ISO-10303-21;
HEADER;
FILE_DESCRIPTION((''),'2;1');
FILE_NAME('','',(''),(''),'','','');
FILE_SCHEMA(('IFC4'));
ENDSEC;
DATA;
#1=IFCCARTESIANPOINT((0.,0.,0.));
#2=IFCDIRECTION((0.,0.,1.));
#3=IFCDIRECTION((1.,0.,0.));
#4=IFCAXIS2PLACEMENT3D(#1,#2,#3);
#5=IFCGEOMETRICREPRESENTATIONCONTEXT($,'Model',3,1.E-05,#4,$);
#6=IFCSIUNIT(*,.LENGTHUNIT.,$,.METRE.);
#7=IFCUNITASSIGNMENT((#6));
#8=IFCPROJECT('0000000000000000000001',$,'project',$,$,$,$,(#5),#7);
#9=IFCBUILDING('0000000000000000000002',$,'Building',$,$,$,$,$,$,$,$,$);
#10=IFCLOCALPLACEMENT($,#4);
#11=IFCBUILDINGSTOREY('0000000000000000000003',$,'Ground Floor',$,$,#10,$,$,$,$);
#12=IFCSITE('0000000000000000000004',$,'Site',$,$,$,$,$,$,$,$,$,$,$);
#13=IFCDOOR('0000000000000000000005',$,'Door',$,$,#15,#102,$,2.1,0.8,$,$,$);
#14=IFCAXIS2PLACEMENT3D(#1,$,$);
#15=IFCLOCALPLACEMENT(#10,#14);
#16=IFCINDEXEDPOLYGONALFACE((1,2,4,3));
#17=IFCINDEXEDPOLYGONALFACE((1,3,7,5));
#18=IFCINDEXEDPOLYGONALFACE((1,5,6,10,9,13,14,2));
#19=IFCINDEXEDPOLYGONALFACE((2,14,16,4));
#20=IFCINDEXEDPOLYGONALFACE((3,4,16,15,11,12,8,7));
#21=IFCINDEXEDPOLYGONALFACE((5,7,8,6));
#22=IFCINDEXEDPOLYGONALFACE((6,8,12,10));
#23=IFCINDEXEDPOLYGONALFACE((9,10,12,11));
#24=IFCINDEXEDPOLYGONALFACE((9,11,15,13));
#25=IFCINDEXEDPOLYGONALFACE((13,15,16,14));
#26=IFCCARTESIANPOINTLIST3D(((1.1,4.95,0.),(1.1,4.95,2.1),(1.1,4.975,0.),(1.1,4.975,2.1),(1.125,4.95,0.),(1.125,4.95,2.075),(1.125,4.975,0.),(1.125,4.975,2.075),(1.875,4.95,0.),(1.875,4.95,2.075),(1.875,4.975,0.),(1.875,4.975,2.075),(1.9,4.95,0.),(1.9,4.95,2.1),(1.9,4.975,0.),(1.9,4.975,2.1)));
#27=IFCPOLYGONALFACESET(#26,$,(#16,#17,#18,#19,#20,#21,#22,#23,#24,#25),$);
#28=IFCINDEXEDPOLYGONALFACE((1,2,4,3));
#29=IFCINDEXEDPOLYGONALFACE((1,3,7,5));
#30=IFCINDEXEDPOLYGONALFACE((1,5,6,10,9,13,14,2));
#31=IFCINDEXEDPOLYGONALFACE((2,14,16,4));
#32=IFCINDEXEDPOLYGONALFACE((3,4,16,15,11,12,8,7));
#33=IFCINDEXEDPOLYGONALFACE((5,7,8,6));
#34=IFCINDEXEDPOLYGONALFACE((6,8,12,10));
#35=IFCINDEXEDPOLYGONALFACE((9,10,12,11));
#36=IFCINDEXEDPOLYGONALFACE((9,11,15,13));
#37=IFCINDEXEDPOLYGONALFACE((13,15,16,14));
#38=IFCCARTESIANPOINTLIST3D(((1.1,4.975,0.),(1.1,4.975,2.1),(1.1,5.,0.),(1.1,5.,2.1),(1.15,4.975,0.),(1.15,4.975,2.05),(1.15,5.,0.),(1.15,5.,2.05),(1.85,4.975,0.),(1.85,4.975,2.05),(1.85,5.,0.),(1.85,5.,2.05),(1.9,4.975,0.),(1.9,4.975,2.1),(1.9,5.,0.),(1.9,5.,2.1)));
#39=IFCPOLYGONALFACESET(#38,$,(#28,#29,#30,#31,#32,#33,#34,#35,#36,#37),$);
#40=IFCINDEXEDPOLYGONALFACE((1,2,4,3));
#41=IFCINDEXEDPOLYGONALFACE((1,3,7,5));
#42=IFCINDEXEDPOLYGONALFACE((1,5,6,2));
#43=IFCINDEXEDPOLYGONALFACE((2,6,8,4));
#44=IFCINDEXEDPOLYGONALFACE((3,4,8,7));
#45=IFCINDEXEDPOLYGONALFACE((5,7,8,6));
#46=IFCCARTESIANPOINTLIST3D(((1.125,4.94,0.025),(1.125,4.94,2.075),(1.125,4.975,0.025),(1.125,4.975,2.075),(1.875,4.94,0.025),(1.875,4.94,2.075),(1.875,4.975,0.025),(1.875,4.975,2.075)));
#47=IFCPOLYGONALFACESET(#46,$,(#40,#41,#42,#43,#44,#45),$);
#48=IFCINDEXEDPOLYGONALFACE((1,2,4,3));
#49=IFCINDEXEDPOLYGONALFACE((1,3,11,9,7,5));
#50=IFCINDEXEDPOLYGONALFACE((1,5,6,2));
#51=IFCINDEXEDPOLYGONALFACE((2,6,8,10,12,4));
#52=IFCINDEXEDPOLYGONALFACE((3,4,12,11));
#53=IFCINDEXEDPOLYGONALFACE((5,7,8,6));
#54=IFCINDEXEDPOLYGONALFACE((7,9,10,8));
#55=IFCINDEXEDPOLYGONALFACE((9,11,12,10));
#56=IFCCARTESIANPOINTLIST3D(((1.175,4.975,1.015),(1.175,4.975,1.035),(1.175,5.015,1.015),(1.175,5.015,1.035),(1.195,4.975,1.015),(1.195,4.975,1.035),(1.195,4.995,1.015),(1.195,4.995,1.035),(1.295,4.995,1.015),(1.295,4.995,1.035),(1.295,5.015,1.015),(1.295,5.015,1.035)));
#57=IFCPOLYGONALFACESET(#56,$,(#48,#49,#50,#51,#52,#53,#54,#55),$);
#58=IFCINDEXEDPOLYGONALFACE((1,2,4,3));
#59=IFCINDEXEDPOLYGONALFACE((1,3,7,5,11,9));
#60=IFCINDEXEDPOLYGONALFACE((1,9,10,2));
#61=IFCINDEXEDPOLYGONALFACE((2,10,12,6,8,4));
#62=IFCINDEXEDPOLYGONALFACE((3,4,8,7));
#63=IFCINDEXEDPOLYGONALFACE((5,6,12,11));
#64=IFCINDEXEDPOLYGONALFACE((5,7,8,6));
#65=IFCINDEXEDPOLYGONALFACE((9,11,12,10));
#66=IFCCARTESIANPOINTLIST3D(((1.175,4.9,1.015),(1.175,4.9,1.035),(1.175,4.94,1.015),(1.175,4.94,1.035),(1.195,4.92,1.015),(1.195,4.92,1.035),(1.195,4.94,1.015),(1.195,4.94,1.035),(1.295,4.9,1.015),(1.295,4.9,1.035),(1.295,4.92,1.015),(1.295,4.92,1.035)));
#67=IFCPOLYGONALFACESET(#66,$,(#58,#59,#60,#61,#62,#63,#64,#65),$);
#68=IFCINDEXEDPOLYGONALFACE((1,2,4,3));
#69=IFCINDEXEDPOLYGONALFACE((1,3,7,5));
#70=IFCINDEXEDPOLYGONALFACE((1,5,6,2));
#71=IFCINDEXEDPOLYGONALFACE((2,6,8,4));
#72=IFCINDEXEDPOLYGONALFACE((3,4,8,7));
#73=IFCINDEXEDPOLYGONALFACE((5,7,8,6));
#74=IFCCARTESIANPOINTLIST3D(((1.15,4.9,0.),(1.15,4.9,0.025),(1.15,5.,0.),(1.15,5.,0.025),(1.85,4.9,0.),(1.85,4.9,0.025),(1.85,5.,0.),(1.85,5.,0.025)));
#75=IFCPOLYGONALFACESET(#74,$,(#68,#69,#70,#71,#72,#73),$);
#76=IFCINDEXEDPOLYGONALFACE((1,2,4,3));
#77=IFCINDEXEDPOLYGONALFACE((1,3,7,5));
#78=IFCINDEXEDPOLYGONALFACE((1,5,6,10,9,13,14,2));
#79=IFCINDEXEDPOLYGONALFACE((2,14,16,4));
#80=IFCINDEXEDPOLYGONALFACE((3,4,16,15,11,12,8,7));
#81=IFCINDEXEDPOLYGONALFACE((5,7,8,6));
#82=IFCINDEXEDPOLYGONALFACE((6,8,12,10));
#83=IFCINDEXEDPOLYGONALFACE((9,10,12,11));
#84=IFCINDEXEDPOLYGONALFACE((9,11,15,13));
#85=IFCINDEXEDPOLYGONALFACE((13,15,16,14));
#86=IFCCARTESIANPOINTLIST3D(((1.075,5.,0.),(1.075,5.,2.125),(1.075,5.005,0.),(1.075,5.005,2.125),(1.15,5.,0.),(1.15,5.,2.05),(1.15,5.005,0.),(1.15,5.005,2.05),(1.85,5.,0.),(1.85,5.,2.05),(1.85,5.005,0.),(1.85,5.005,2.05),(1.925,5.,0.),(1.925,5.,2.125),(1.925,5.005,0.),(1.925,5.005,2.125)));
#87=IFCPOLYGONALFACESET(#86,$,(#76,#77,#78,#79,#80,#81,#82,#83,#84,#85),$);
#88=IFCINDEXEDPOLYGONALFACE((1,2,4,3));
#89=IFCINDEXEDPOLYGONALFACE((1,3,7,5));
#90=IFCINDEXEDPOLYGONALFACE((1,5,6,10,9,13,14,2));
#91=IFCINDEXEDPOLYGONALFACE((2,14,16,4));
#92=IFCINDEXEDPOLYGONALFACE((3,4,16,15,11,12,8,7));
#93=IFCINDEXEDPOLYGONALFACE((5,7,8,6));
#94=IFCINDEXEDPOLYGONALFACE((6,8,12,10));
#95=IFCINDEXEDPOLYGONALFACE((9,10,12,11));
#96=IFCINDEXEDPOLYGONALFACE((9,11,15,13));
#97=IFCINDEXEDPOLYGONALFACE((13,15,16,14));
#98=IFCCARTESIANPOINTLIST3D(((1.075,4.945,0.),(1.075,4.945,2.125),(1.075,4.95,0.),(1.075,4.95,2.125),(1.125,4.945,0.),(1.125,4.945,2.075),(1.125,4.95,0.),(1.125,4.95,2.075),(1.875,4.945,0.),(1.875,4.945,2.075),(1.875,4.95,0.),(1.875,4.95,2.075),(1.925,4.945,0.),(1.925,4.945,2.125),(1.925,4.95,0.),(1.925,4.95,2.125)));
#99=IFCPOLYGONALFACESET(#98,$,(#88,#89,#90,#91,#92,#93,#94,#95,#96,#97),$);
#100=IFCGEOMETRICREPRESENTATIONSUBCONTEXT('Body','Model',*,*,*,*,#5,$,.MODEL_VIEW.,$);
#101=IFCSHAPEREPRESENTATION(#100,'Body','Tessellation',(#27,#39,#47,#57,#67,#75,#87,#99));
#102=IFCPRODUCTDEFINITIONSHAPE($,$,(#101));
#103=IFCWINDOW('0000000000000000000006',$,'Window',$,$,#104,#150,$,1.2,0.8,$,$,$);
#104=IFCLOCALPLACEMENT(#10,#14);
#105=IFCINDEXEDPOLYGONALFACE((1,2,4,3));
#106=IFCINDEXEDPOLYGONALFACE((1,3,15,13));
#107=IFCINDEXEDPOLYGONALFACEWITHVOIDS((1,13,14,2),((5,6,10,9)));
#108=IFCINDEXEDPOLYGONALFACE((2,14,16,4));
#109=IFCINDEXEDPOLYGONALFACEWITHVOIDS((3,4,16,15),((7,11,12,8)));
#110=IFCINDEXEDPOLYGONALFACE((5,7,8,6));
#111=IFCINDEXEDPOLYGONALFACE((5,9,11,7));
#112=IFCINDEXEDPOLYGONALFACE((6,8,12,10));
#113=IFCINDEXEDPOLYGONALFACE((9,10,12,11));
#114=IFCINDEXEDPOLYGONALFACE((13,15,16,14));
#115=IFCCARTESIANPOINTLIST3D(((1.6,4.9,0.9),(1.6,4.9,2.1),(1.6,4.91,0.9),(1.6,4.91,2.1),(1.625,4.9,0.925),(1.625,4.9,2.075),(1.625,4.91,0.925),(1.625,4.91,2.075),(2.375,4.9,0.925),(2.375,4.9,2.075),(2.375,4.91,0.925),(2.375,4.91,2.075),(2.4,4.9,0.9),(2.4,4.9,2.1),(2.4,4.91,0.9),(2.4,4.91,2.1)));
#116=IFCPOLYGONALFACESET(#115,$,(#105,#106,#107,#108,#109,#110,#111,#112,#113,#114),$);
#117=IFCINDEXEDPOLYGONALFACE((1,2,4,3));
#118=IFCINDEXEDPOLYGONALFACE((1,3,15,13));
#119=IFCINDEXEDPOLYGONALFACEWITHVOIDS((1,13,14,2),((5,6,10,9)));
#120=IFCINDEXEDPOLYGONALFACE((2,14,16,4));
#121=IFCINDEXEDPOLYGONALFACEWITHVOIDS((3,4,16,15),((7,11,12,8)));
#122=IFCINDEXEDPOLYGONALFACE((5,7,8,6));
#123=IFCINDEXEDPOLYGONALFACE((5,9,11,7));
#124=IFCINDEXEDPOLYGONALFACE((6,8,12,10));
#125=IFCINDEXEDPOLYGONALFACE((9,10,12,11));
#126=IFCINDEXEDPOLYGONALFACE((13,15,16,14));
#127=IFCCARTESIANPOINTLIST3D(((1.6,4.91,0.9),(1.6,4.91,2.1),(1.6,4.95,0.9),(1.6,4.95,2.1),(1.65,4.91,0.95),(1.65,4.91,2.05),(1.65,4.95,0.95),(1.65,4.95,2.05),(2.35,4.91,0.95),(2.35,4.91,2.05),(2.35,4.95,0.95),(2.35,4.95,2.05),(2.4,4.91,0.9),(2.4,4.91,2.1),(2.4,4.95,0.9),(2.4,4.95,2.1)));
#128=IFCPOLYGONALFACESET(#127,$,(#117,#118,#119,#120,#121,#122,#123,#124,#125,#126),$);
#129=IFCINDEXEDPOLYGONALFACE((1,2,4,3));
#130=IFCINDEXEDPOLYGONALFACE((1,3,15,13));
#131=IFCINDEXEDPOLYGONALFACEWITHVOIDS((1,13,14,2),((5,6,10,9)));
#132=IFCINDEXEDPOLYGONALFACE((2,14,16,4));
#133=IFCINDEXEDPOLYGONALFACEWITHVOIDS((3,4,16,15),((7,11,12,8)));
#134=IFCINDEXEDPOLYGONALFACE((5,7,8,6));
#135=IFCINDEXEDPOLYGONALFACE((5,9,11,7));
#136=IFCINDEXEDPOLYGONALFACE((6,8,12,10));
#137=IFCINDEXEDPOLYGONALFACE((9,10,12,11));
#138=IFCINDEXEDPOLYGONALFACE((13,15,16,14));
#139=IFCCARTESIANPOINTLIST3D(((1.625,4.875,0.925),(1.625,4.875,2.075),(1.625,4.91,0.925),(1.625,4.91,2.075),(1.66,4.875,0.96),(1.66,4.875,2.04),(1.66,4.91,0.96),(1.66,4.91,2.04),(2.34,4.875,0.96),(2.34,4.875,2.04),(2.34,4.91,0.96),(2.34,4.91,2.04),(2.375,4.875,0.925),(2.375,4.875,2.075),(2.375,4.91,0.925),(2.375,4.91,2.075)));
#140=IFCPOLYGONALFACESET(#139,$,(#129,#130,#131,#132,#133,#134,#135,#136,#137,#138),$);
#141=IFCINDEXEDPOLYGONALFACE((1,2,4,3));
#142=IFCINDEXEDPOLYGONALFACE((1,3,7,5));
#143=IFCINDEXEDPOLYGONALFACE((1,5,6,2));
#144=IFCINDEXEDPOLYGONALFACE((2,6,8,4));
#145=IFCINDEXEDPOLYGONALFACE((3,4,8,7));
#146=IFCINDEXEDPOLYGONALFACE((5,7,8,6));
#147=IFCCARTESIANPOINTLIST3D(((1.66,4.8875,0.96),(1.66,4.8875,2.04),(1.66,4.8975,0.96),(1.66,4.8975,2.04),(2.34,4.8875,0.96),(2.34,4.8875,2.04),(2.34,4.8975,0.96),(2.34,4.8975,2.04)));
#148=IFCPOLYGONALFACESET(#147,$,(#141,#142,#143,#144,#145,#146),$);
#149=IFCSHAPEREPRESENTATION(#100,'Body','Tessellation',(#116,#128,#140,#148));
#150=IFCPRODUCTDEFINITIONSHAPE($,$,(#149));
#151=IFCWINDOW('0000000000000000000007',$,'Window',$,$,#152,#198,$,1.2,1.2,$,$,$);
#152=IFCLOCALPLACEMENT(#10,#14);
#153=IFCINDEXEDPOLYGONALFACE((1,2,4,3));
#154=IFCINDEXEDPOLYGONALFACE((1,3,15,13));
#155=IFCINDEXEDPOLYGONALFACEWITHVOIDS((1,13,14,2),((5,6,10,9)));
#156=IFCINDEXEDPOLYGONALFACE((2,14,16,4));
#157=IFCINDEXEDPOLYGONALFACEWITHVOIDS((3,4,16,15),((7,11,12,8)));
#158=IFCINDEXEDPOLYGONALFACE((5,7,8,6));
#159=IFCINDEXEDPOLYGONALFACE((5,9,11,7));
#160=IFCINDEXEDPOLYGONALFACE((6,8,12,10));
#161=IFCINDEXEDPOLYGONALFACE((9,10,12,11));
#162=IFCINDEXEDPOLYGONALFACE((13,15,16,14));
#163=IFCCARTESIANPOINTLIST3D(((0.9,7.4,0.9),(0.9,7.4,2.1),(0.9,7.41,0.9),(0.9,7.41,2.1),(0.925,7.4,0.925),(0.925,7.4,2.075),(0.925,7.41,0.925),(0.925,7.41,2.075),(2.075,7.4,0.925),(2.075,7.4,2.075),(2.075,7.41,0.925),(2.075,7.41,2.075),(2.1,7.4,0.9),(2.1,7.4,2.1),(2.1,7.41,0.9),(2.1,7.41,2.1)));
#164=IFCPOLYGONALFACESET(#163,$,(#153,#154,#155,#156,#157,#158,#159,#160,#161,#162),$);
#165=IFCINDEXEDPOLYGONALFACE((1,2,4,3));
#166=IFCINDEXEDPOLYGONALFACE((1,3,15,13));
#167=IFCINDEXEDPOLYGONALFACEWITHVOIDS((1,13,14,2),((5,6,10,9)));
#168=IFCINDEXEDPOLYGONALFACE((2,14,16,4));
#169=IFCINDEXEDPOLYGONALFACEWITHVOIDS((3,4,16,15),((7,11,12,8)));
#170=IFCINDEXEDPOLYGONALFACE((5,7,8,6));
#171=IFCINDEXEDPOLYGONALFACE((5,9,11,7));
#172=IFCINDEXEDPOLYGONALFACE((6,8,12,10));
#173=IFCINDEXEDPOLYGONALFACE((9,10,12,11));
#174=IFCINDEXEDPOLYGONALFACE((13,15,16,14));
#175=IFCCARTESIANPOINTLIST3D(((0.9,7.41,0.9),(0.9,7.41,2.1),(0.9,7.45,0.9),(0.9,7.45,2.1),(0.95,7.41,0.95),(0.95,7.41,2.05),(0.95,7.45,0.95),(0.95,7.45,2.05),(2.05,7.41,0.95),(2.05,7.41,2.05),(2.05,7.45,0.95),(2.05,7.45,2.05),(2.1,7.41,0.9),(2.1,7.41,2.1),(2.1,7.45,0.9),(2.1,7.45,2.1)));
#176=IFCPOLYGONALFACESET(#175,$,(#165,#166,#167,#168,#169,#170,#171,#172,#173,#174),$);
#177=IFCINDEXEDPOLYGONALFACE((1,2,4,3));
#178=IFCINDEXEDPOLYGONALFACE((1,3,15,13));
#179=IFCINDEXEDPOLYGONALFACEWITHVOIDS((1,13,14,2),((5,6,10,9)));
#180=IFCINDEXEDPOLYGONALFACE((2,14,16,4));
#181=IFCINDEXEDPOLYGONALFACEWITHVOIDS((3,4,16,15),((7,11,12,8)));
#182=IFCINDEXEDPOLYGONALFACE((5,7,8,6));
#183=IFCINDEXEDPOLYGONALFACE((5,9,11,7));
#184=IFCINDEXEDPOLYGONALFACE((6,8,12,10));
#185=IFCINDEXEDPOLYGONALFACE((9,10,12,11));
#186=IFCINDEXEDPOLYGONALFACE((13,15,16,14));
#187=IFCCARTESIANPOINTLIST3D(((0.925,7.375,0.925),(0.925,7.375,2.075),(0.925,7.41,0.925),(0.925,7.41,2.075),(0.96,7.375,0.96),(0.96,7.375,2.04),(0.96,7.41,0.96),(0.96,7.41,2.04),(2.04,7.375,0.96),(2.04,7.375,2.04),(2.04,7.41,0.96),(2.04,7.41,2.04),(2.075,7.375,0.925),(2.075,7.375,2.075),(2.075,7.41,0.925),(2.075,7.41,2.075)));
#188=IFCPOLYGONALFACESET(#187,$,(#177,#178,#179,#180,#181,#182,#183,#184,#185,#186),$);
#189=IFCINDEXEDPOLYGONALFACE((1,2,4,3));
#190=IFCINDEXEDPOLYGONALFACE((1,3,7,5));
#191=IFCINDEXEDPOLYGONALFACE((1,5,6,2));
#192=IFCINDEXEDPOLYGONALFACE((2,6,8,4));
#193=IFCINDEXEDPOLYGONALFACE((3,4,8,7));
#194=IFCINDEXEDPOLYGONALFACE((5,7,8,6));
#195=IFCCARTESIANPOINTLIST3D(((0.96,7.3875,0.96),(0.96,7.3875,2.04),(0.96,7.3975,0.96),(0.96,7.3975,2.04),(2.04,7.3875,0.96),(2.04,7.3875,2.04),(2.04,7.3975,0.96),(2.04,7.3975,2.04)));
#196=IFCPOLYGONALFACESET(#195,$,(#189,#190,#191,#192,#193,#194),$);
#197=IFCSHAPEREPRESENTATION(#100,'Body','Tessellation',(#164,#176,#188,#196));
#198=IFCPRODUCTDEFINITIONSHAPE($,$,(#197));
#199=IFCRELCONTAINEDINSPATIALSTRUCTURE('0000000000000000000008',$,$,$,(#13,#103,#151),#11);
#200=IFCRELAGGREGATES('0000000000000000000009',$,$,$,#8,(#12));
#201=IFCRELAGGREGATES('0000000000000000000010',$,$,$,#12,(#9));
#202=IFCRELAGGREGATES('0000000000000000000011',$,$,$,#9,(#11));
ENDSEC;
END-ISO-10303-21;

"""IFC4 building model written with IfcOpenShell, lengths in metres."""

from ifc_helpers import new_model, si_unit, frame, origin_with_axes, place, context, subcontext, project, spatial, line, indexed_curve, outline, extrude, element, save


model = new_model("IFC4")

# Units and contexts
model_context = context("Model", 3, precision=1e-05, world=origin_with_axes())
body_context = subcontext(model_context, "Body", "Model", "MODEL_VIEW")
ifc_project = project(units=[si_unit("LENGTHUNIT", "METRE")], contexts=[model_context])

# Site, building, storey
site = spatial("IfcSite", under=ifc_project, Name="Site")
building = spatial("IfcBuilding", under=site, Name="Building")
storey_placement = place(None, origin_with_axes())
storey = spatial("IfcBuildingStorey", under=building, at=storey_placement, Name="Ground Floor")

# Door
door_1_placement = place(storey_placement, frame((1.9, 5.0, 0.0), z_axis=(0.0, 0.0, 1.0), x_axis=(-1.0, 0.0, 0.0)))
element("IfcDoor", 1, at=door_1_placement, inside=storey, Name="Door", OverallHeight=2.1, OverallWidth=0.8, context=body_context, shape_type="SweptSolid", body=[
    extrude(outline(indexed_curve([(0.0, 0.0), (0.0, 2.1), (0.8, 2.1), (0.8, 0.0), (0.775, 0.0), (0.775, 2.075), (0.025, 2.075), (0.025, 0.0)], segments=[line(1, 2, 3, 4, 5, 6, 7, 8, 1)])), frame((0.0, 0.025, 0.0), z_axis=(0.0, -1.0, 0.0), x_axis=(1.0, 0.0, 0.0)), (0.0, 0.0, -1.0), 0.025),
    extrude(outline(indexed_curve([(0.0, 0.0), (0.0, 2.1), (0.8, 2.1), (0.8, 0.0), (0.75, 0.0), (0.75, 2.05), (0.05, 2.05), (0.05, 0.0)], segments=[line(1, 2, 3, 4, 5, 6, 7, 8, 1)])), frame((0.0, 0.0, 0.0), z_axis=(0.0, -1.0, 0.0), x_axis=(1.0, 0.0, 0.0)), (0.0, 0.0, -1.0), 0.025),
    extrude(outline(indexed_curve([(0.0, 0.0), (0.75, 0.0), (0.75, 0.035), (0.0, 0.035)], segments=[line(1, 2, 3, 4, 1)])), frame((0.025, 0.025, 0.025), z_axis=(0.0, 0.0, 1.0), x_axis=(1.0, 0.0, 0.0)), (0.0, 0.0, 1.0), 2.05),
    extrude(outline(indexed_curve([(0.0, 0.0), (0.0, -0.04), (-0.12, -0.04), (-0.12, -0.02), (-0.02, -0.02), (-0.02, 0.0)], segments=[line(1, 2, 3, 4, 5, 6, 1)])), frame((0.725, 0.025, 1.015), z_axis=(0.0, 0.0, 1.0), x_axis=(1.0, 0.0, 0.0)), (0.0, 0.0, 1.0), 0.02),
    extrude(outline(indexed_curve([(0.0, 0.0), (0.0, 0.04), (-0.12, 0.04), (-0.12, 0.02), (-0.02, 0.02), (-0.02, 0.0)], segments=[line(1, 2, 3, 4, 5, 6, 1)])), frame((0.725, 0.06, 1.015), z_axis=(0.0, 0.0, 1.0), x_axis=(1.0, 0.0, 0.0)), (0.0, 0.0, 1.0), 0.02),
    extrude(outline(indexed_curve([(0.0, 0.0), (0.7, 0.0), (0.7, 0.1), (0.0, 0.1)], segments=[line(1, 2, 3, 4, 1)])), frame((0.05, 0.0, 0.0), z_axis=(0.0, 0.0, 1.0), x_axis=(1.0, 0.0, 0.0)), (0.0, 0.0, 1.0), 0.025),
    extrude(outline(indexed_curve([(0.0, 0.0), (0.0, 2.125), (0.85, 2.125), (0.85, 0.0), (0.775, 0.0), (0.775, 2.05), (0.075, 2.05), (0.075, 0.0)], segments=[line(1, 2, 3, 4, 5, 6, 7, 8, 1)])), frame((-0.025, -0.005, 0.0), z_axis=(0.0, -1.0, 0.0), x_axis=(1.0, 0.0, 0.0)), (0.0, 0.0, -1.0), 0.005),
    extrude(outline(indexed_curve([(0.0, 0.0), (0.0, 2.125), (0.85, 2.125), (0.85, 0.0), (0.8, 0.0), (0.8, 2.075), (0.05, 2.075), (0.05, 0.0)], segments=[line(1, 2, 3, 4, 5, 6, 7, 8, 1)])), frame((-0.025, 0.05, 0.0), z_axis=(0.0, -1.0, 0.0), x_axis=(1.0, 0.0, 0.0)), (0.0, 0.0, -1.0), 0.005),
])

# Windows
window_1_placement = place(storey_placement, frame((2.4, 5.0, 0.9), z_axis=(0.0, 0.0, 1.0), x_axis=(-1.0, 0.0, 0.0)))
element("IfcWindow", 2, at=window_1_placement, inside=storey, Name="Window", OverallHeight=1.2, OverallWidth=0.8, context=body_context, shape_type="SweptSolid", body=[
    extrude(outline(indexed_curve([(0.0, 0.0), (0.8, 0.0), (0.8, 1.2), (0.0, 1.2)], segments=[line(1, 2, 3, 4, 1)]), holes=[indexed_curve([(0.025, 0.025), (0.775, 0.025), (0.775, 1.175), (0.025, 1.175)], segments=[line(1, 2, 3, 4, 1)])]), frame((0.0, 0.09, 0.0), z_axis=(0.0, -1.0, 0.0), x_axis=(1.0, 0.0, 0.0)), (0.0, 0.0, -1.0), 0.01),
    extrude(outline(indexed_curve([(0.0, 0.0), (0.8, 0.0), (0.8, 1.2), (0.0, 1.2)], segments=[line(1, 2, 3, 4, 1)]), holes=[indexed_curve([(0.05, 0.05), (0.75, 0.05), (0.75, 1.15), (0.05, 1.15)], segments=[line(1, 2, 3, 4, 1)])]), frame((0.0, 0.05, 0.0), z_axis=(0.0, -1.0, 0.0), x_axis=(1.0, 0.0, 0.0)), (0.0, 0.0, -1.0), 0.04),
    extrude(outline(indexed_curve([(0.0, 0.0), (0.75, 0.0), (0.75, 1.15), (0.0, 1.15)], segments=[line(1, 2, 3, 4, 1)]), holes=[indexed_curve([(0.035, 0.035), (0.715, 0.035), (0.715, 1.115), (0.035, 1.115)], segments=[line(1, 2, 3, 4, 1)])]), frame((0.025, 0.09, 0.025), z_axis=(0.0, -1.0, 0.0), x_axis=(1.0, 0.0, 0.0)), (0.0, 0.0, -1.0), 0.035),
    extrude(outline(indexed_curve([(0.035, 0.035), (0.715, 0.035), (0.715, 1.115), (0.035, 1.115)], segments=[line(1, 2, 3, 4, 1)])), frame((0.025, 0.1025, 0.025), z_axis=(0.0, -1.0, 0.0), x_axis=(1.0, 0.0, 0.0)), (0.0, 0.0, -1.0), 0.01),
])
window_2_placement = place(storey_placement, frame((2.1, 7.5, 0.9), z_axis=(0.0, 0.0, 1.0), x_axis=(-1.0, 0.0, 0.0)))
element("IfcWindow", 3, at=window_2_placement, inside=storey, Name="Window", OverallHeight=1.2, OverallWidth=1.2, context=body_context, shape_type="SweptSolid", body=[
    extrude(outline(indexed_curve([(0.0, 0.0), (1.2, 0.0), (1.2, 1.2), (0.0, 1.2)], segments=[line(1, 2, 3, 4, 1)]), holes=[indexed_curve([(0.025, 0.025), (1.175, 0.025), (1.175, 1.175), (0.025, 1.175)], segments=[line(1, 2, 3, 4, 1)])]), frame((0.0, 0.09, 0.0), z_axis=(0.0, -1.0, 0.0), x_axis=(1.0, 0.0, 0.0)), (0.0, 0.0, -1.0), 0.01),
    extrude(outline(indexed_curve([(0.0, 0.0), (1.2, 0.0), (1.2, 1.2), (0.0, 1.2)], segments=[line(1, 2, 3, 4, 1)]), holes=[indexed_curve([(0.05, 0.05), (1.15, 0.05), (1.15, 1.15), (0.05, 1.15)], segments=[line(1, 2, 3, 4, 1)])]), frame((0.0, 0.05, 0.0), z_axis=(0.0, -1.0, 0.0), x_axis=(1.0, 0.0, 0.0)), (0.0, 0.0, -1.0), 0.04),
    extrude(outline(indexed_curve([(0.0, 0.0), (1.15, 0.0), (1.15, 1.15), (0.0, 1.15)], segments=[line(1, 2, 3, 4, 1)]), holes=[indexed_curve([(0.035, 0.035), (1.115, 0.035), (1.115, 1.115), (0.035, 1.115)], segments=[line(1, 2, 3, 4, 1)])]), frame((0.025, 0.09, 0.025), z_axis=(0.0, -1.0, 0.0), x_axis=(1.0, 0.0, 0.0)), (0.0, 0.0, -1.0), 0.035),
    extrude(outline(indexed_curve([(0.035, 0.035), (1.115, 0.035), (1.115, 1.115), (0.035, 1.115)], segments=[line(1, 2, 3, 4, 1)])), frame((0.025, 0.1025, 0.025), z_axis=(0.0, -1.0, 0.0), x_axis=(1.0, 0.0, 0.0)), (0.0, 0.0, -1.0), 0.01),
])

save(model, "model.ifc")
